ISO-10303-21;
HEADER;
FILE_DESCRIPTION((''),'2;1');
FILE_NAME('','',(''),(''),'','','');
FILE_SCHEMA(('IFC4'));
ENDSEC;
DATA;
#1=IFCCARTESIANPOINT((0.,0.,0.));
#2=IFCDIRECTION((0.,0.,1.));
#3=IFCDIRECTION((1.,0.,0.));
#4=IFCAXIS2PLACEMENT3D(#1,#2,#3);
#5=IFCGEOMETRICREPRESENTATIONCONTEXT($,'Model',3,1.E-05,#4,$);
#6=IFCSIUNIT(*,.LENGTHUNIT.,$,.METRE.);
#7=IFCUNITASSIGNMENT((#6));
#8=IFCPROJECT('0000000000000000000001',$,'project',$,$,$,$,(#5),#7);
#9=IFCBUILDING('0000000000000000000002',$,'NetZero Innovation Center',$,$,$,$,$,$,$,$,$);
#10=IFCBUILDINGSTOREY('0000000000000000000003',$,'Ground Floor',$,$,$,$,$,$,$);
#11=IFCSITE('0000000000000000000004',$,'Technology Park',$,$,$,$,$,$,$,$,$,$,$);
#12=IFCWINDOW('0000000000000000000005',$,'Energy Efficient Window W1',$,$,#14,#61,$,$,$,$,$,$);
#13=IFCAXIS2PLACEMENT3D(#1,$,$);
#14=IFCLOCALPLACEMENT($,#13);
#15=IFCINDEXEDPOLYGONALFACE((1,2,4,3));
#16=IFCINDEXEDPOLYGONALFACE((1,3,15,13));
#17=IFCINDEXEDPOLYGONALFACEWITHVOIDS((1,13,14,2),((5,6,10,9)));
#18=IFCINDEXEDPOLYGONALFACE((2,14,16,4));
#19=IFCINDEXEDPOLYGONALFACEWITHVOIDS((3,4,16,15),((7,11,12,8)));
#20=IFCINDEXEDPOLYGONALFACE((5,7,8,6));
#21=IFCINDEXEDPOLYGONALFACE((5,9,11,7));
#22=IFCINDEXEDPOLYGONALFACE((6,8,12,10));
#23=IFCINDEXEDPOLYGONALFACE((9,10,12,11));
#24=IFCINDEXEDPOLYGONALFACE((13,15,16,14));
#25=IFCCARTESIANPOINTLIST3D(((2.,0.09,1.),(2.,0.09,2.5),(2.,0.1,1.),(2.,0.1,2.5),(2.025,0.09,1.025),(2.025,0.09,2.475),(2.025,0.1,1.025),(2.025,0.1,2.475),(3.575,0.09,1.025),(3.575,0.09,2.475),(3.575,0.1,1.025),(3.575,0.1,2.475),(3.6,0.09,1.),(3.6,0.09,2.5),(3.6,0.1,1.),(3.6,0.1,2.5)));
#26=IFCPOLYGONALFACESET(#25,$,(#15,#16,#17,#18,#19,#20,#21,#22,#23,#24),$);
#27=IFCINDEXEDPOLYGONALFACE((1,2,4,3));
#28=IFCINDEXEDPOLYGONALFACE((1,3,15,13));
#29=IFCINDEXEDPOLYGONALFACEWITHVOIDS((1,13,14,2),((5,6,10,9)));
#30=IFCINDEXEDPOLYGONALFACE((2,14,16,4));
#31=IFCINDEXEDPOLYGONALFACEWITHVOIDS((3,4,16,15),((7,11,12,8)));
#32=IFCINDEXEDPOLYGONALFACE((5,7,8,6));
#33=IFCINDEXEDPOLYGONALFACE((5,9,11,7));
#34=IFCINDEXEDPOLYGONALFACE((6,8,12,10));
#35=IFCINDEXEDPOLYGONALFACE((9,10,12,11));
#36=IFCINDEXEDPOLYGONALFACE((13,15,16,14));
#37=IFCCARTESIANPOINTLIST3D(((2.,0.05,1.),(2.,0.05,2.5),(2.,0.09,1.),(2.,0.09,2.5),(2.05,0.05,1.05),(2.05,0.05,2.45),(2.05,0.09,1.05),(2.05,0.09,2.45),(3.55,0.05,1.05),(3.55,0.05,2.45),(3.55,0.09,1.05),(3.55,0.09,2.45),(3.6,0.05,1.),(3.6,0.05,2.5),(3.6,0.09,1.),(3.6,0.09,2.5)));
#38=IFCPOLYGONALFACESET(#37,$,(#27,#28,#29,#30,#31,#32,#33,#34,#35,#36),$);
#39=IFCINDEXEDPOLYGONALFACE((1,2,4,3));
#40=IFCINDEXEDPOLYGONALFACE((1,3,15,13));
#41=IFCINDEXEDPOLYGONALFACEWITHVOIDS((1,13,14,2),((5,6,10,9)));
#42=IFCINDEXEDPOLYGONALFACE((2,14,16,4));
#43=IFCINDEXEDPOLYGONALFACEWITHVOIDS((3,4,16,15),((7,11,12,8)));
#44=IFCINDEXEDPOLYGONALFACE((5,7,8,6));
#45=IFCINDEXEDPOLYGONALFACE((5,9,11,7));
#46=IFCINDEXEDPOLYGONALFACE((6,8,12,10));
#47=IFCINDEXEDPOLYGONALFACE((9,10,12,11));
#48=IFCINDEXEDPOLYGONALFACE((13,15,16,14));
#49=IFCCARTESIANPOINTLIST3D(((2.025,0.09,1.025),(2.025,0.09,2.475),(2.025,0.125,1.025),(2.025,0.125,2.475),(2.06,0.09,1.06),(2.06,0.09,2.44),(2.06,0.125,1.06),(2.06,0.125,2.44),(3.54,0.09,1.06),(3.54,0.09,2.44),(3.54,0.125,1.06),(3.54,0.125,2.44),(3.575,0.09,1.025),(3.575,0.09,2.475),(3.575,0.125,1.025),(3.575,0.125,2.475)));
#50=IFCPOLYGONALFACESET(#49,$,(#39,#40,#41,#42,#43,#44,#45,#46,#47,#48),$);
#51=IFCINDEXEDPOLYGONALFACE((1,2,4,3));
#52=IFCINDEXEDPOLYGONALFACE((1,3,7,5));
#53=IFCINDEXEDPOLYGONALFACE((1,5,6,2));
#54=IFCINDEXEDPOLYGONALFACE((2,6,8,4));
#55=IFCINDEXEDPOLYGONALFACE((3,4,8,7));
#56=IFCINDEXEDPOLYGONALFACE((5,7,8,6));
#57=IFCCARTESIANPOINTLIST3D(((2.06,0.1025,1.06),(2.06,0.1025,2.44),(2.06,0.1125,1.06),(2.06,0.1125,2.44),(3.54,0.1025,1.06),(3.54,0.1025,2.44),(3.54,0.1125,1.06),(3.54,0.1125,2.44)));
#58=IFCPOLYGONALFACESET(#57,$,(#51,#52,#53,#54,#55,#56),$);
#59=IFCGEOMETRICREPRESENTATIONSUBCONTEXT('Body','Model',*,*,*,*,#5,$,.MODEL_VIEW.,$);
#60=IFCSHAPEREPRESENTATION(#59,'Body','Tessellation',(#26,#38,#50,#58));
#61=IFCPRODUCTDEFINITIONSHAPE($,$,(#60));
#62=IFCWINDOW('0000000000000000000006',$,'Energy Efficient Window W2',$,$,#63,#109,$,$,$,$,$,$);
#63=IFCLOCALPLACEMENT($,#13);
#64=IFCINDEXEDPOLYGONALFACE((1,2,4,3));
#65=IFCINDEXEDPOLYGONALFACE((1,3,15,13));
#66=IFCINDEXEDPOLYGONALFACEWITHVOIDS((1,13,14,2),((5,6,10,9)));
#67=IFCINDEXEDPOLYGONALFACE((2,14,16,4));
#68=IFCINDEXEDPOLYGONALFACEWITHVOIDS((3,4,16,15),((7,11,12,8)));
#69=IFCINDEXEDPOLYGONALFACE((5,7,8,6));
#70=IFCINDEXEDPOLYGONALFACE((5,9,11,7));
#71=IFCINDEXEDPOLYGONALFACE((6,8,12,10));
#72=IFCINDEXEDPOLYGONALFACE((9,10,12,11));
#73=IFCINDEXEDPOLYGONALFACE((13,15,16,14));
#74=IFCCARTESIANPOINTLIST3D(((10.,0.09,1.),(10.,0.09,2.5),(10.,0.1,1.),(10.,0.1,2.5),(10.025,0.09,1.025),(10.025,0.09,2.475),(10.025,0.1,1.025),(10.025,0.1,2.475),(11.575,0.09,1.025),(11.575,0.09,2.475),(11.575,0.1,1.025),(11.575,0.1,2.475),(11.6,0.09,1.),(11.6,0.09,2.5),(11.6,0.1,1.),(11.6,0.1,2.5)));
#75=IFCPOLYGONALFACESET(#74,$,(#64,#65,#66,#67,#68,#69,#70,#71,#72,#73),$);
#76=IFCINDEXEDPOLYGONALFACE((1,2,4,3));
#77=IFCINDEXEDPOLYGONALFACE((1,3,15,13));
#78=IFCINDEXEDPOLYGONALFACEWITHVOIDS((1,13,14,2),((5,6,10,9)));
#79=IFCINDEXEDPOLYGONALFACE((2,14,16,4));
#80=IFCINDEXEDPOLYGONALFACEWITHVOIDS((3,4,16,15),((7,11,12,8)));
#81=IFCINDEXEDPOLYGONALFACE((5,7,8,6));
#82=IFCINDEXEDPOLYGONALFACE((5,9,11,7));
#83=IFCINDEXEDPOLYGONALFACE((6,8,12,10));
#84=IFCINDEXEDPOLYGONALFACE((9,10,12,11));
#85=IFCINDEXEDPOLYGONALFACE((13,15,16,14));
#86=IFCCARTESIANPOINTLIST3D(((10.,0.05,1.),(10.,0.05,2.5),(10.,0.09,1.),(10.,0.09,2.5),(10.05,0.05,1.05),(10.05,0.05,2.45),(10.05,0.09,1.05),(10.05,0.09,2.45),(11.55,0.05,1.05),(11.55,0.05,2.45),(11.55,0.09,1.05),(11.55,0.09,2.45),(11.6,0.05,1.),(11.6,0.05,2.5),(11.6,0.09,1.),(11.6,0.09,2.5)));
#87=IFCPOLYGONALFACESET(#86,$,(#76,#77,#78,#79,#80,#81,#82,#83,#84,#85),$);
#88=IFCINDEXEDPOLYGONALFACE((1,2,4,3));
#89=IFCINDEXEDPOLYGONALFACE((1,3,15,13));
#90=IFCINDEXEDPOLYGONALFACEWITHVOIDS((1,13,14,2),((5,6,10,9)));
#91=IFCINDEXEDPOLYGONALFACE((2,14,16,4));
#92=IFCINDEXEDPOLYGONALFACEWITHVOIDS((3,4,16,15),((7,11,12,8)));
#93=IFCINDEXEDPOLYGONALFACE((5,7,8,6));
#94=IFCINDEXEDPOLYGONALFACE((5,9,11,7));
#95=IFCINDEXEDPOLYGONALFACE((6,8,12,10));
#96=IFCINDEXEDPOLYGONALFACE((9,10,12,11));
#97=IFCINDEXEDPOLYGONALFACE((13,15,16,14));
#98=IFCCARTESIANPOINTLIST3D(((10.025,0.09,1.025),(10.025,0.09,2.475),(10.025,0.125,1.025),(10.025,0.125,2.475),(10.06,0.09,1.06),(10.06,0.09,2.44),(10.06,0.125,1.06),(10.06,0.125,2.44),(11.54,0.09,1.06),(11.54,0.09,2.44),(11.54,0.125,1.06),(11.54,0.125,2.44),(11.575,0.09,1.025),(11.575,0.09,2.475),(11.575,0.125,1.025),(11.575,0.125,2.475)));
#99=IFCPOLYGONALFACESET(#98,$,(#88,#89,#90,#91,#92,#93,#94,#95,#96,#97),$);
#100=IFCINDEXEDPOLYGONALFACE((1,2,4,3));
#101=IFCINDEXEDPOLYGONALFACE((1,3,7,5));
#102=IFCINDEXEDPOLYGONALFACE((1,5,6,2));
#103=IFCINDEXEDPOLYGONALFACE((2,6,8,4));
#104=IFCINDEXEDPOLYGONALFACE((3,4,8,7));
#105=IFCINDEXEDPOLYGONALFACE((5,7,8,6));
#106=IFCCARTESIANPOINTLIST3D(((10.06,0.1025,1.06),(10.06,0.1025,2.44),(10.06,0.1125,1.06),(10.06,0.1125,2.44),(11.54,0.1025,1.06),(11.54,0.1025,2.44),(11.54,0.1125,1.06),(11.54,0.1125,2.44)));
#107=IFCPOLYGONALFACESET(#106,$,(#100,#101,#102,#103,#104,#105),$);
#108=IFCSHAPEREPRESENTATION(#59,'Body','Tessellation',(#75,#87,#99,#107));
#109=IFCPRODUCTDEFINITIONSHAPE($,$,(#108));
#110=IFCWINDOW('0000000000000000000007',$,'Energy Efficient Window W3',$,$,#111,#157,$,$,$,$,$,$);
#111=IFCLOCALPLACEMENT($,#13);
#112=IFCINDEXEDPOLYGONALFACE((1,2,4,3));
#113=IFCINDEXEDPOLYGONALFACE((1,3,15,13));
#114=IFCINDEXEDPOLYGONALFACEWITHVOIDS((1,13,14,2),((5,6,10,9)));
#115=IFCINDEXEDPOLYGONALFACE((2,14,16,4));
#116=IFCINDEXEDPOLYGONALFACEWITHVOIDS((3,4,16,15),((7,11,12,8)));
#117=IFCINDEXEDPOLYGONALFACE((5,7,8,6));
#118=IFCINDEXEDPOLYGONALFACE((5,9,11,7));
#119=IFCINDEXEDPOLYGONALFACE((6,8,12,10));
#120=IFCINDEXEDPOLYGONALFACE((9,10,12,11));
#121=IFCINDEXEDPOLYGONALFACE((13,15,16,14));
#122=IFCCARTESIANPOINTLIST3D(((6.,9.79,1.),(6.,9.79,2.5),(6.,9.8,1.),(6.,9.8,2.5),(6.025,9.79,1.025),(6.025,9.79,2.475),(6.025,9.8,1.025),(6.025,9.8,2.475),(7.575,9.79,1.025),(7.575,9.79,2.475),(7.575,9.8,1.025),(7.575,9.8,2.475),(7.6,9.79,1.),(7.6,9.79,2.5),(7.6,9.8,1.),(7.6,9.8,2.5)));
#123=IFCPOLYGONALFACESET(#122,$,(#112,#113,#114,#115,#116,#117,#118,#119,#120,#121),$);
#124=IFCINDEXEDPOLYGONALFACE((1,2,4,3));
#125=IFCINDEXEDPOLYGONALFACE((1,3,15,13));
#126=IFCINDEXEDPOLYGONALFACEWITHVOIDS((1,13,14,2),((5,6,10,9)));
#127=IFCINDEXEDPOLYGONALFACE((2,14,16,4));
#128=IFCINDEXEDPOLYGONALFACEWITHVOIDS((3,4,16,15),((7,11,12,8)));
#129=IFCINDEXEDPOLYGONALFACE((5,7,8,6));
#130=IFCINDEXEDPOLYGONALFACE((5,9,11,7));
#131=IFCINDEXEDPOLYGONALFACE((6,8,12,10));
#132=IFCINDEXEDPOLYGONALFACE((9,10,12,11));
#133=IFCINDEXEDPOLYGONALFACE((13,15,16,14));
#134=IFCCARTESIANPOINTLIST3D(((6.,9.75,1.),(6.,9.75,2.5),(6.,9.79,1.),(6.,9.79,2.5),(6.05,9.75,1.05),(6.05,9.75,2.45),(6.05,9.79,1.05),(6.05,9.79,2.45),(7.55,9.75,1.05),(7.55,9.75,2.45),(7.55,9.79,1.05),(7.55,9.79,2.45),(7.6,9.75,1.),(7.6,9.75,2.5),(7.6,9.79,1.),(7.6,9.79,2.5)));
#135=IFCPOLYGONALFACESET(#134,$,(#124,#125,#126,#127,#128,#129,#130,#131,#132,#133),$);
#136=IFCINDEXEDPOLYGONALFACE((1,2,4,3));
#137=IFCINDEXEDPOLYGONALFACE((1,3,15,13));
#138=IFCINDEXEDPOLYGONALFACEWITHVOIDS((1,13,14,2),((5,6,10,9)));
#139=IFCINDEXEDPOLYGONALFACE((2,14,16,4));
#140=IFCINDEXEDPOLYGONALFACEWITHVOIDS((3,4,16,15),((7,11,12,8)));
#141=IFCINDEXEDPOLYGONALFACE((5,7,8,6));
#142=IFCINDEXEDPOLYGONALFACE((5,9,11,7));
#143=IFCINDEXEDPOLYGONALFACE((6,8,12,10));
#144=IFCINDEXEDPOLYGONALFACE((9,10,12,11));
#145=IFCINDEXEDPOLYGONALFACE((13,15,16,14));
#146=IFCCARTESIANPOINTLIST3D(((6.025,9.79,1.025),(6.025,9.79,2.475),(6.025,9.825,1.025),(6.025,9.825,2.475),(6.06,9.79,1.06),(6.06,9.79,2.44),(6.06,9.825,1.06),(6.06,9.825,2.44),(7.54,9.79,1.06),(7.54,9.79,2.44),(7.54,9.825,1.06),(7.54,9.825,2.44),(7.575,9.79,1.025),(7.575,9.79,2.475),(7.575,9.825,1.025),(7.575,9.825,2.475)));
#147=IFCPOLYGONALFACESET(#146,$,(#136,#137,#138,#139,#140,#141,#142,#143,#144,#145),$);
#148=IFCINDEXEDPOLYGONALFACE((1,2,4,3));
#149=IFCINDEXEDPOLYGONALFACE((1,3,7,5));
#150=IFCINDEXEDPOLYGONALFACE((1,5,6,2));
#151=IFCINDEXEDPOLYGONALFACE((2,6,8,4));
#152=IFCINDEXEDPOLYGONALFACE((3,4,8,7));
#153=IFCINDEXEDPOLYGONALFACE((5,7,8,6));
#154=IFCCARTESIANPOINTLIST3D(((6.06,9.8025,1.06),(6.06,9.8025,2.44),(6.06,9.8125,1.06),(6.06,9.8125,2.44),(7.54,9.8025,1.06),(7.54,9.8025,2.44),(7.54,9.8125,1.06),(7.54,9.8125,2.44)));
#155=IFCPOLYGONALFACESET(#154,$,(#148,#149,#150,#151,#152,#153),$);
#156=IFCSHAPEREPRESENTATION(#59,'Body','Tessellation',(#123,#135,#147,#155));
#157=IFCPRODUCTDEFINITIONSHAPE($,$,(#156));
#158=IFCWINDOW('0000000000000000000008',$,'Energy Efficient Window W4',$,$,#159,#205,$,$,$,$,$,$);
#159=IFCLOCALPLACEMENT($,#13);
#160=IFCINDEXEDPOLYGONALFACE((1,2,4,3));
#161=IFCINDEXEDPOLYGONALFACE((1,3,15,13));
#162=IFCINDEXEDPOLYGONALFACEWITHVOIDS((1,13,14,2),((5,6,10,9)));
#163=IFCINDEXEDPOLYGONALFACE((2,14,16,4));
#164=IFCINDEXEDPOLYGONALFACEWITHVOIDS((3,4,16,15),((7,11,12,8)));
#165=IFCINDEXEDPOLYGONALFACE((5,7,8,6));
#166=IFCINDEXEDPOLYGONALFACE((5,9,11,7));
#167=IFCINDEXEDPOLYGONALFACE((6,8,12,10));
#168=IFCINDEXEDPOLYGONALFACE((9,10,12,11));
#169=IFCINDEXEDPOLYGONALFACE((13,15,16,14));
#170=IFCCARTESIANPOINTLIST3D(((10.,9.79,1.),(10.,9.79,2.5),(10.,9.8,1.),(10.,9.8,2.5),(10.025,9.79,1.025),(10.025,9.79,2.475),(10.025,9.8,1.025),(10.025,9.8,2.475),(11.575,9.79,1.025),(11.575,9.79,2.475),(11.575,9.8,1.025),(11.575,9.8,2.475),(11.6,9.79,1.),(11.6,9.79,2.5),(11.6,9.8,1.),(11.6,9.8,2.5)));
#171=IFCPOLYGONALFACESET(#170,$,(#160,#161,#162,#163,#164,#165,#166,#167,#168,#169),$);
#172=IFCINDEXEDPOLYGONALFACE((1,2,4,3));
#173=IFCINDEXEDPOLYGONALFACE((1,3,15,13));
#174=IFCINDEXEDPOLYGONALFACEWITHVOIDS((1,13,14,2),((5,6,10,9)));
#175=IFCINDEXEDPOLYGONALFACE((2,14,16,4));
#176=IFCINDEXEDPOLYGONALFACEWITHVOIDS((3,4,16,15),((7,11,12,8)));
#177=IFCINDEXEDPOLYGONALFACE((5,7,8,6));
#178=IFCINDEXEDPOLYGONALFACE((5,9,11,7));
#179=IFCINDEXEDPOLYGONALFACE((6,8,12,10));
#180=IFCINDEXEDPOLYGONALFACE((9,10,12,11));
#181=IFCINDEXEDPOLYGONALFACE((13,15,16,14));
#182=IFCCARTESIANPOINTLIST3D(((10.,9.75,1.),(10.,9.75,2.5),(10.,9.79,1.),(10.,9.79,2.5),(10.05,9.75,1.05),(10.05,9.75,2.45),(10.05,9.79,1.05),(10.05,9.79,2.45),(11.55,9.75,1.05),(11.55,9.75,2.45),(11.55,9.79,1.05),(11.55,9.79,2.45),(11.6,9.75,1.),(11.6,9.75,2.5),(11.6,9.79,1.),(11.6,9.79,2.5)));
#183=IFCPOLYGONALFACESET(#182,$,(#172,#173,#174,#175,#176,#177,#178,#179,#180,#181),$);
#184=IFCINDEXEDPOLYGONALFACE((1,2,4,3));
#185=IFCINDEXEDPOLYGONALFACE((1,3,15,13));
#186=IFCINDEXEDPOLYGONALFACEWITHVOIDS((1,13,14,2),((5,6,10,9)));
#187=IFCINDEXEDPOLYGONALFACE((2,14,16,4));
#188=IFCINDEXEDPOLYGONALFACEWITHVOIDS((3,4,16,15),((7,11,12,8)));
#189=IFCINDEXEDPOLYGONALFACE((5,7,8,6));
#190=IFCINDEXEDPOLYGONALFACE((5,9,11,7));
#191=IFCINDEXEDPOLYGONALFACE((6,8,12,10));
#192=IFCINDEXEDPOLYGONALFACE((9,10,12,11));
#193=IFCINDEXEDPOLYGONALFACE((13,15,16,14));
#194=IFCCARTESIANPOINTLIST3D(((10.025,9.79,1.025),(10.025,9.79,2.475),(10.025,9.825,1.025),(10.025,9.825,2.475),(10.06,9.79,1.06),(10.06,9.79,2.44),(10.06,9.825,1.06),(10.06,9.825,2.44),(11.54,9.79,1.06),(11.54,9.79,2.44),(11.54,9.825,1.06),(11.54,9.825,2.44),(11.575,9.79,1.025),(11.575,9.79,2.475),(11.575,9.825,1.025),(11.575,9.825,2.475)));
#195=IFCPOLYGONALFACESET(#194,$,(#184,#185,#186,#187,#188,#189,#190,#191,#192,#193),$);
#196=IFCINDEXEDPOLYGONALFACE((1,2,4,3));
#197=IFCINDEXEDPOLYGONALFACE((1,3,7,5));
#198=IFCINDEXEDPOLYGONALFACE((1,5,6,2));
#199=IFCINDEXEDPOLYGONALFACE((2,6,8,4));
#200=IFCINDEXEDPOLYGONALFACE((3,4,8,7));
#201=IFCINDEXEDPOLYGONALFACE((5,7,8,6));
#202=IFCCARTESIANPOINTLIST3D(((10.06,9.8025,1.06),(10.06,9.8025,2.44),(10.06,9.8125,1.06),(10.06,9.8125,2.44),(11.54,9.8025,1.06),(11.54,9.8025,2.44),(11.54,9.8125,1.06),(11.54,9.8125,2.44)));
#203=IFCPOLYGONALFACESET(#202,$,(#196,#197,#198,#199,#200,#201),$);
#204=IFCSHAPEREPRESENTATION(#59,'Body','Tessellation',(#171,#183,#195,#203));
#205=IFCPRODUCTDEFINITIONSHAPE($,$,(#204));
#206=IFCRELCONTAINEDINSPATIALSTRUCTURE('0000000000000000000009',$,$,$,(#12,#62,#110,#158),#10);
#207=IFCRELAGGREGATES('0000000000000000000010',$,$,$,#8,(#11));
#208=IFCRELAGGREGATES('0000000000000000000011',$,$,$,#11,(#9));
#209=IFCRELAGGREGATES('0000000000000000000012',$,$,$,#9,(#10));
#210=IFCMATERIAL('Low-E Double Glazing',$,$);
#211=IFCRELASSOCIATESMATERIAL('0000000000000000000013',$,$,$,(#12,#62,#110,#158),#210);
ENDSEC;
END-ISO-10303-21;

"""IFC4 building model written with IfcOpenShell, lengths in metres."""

from ifc_helpers import new_model, si_unit, frame, origin_with_axes, place, context, subcontext, project, spatial, line, indexed_curve, outline, extrude, material, element, save


model = new_model("IFC4")

# Units and contexts
model_context = context("Model", 3, precision=1e-05, world=origin_with_axes())
body_context = subcontext(model_context, "Body", "Model", "MODEL_VIEW")
ifc_project = project(units=[si_unit("LENGTHUNIT", "METRE")], contexts=[model_context])

# Site, building, storey
site = spatial("IfcSite", under=ifc_project, Name="Technology Park")
building = spatial("IfcBuilding", under=site, Name="NetZero Innovation Center")
storey = spatial("IfcBuildingStorey", under=building, Name="Ground Floor")

# Windows
ifc_material_1 = material(Name="Low-E Double Glazing")
for number, where, z_axis, x_axis, name in (
    (1, (2.0, 0.0, 1.0), (0.0, 0.0, 1.0), (1.0, 0.0, 0.0), "Energy Efficient Window W1"),
    (2, (10.0, 0.0, 1.0), (0.0, 0.0, 1.0), (1.0, 0.0, 0.0), "Energy Efficient Window W2"),
    (3, (6.0, 9.7, 1.0), (0.0, 0.0, 1.0), (1.0, 0.0, 0.0), "Energy Efficient Window W3"),
    (4, (10.0, 9.7, 1.0), (0.0, 0.0, 1.0), (1.0, 0.0, 0.0), "Energy Efficient Window W4"),
):
    element("IfcWindow", number, at=place(None, frame(where, z_axis=z_axis, x_axis=x_axis)), inside=storey, material=ifc_material_1, Name=name, context=body_context, shape_type="SweptSolid", body=[
        extrude(outline(indexed_curve([(0.0, 0.0), (1.6, 0.0), (1.6, 1.5), (0.0, 1.5)], segments=[line(1, 2, 3, 4, 1)]), holes=[indexed_curve([(0.025, 0.025), (1.575, 0.025), (1.575, 1.475), (0.025, 1.475)], segments=[line(1, 2, 3, 4, 1)])]), frame((0.0, 0.09, 0.0), z_axis=(0.0, -1.0, 0.0), x_axis=(1.0, 0.0, 0.0)), (0.0, 0.0, -1.0), 0.01),
        extrude(outline(indexed_curve([(0.0, 0.0), (1.6, 0.0), (1.6, 1.5), (0.0, 1.5)], segments=[line(1, 2, 3, 4, 1)]), holes=[indexed_curve([(0.05, 0.05), (1.55, 0.05), (1.55, 1.45), (0.05, 1.45)], segments=[line(1, 2, 3, 4, 1)])]), frame((0.0, 0.05, 0.0), z_axis=(0.0, -1.0, 0.0), x_axis=(1.0, 0.0, 0.0)), (0.0, 0.0, -1.0), 0.04),
        extrude(outline(indexed_curve([(0.0, 0.0), (1.55, 0.0), (1.55, 1.45), (0.0, 1.45)], segments=[line(1, 2, 3, 4, 1)]), holes=[indexed_curve([(0.035, 0.035), (1.515, 0.035), (1.515, 1.415), (0.035, 1.415)], segments=[line(1, 2, 3, 4, 1)])]), frame((0.025, 0.09, 0.025), z_axis=(0.0, -1.0, 0.0), x_axis=(1.0, 0.0, 0.0)), (0.0, 0.0, -1.0), 0.035),
        extrude(outline(indexed_curve([(0.035, 0.035), (1.515, 0.035), (1.515, 1.415), (0.035, 1.415)], segments=[line(1, 2, 3, 4, 1)])), frame((0.025, 0.1025, 0.025), z_axis=(0.0, -1.0, 0.0), x_axis=(1.0, 0.0, 0.0)), (0.0, 0.0, -1.0), 0.01),
    ])

save(model, "model.ifc")
